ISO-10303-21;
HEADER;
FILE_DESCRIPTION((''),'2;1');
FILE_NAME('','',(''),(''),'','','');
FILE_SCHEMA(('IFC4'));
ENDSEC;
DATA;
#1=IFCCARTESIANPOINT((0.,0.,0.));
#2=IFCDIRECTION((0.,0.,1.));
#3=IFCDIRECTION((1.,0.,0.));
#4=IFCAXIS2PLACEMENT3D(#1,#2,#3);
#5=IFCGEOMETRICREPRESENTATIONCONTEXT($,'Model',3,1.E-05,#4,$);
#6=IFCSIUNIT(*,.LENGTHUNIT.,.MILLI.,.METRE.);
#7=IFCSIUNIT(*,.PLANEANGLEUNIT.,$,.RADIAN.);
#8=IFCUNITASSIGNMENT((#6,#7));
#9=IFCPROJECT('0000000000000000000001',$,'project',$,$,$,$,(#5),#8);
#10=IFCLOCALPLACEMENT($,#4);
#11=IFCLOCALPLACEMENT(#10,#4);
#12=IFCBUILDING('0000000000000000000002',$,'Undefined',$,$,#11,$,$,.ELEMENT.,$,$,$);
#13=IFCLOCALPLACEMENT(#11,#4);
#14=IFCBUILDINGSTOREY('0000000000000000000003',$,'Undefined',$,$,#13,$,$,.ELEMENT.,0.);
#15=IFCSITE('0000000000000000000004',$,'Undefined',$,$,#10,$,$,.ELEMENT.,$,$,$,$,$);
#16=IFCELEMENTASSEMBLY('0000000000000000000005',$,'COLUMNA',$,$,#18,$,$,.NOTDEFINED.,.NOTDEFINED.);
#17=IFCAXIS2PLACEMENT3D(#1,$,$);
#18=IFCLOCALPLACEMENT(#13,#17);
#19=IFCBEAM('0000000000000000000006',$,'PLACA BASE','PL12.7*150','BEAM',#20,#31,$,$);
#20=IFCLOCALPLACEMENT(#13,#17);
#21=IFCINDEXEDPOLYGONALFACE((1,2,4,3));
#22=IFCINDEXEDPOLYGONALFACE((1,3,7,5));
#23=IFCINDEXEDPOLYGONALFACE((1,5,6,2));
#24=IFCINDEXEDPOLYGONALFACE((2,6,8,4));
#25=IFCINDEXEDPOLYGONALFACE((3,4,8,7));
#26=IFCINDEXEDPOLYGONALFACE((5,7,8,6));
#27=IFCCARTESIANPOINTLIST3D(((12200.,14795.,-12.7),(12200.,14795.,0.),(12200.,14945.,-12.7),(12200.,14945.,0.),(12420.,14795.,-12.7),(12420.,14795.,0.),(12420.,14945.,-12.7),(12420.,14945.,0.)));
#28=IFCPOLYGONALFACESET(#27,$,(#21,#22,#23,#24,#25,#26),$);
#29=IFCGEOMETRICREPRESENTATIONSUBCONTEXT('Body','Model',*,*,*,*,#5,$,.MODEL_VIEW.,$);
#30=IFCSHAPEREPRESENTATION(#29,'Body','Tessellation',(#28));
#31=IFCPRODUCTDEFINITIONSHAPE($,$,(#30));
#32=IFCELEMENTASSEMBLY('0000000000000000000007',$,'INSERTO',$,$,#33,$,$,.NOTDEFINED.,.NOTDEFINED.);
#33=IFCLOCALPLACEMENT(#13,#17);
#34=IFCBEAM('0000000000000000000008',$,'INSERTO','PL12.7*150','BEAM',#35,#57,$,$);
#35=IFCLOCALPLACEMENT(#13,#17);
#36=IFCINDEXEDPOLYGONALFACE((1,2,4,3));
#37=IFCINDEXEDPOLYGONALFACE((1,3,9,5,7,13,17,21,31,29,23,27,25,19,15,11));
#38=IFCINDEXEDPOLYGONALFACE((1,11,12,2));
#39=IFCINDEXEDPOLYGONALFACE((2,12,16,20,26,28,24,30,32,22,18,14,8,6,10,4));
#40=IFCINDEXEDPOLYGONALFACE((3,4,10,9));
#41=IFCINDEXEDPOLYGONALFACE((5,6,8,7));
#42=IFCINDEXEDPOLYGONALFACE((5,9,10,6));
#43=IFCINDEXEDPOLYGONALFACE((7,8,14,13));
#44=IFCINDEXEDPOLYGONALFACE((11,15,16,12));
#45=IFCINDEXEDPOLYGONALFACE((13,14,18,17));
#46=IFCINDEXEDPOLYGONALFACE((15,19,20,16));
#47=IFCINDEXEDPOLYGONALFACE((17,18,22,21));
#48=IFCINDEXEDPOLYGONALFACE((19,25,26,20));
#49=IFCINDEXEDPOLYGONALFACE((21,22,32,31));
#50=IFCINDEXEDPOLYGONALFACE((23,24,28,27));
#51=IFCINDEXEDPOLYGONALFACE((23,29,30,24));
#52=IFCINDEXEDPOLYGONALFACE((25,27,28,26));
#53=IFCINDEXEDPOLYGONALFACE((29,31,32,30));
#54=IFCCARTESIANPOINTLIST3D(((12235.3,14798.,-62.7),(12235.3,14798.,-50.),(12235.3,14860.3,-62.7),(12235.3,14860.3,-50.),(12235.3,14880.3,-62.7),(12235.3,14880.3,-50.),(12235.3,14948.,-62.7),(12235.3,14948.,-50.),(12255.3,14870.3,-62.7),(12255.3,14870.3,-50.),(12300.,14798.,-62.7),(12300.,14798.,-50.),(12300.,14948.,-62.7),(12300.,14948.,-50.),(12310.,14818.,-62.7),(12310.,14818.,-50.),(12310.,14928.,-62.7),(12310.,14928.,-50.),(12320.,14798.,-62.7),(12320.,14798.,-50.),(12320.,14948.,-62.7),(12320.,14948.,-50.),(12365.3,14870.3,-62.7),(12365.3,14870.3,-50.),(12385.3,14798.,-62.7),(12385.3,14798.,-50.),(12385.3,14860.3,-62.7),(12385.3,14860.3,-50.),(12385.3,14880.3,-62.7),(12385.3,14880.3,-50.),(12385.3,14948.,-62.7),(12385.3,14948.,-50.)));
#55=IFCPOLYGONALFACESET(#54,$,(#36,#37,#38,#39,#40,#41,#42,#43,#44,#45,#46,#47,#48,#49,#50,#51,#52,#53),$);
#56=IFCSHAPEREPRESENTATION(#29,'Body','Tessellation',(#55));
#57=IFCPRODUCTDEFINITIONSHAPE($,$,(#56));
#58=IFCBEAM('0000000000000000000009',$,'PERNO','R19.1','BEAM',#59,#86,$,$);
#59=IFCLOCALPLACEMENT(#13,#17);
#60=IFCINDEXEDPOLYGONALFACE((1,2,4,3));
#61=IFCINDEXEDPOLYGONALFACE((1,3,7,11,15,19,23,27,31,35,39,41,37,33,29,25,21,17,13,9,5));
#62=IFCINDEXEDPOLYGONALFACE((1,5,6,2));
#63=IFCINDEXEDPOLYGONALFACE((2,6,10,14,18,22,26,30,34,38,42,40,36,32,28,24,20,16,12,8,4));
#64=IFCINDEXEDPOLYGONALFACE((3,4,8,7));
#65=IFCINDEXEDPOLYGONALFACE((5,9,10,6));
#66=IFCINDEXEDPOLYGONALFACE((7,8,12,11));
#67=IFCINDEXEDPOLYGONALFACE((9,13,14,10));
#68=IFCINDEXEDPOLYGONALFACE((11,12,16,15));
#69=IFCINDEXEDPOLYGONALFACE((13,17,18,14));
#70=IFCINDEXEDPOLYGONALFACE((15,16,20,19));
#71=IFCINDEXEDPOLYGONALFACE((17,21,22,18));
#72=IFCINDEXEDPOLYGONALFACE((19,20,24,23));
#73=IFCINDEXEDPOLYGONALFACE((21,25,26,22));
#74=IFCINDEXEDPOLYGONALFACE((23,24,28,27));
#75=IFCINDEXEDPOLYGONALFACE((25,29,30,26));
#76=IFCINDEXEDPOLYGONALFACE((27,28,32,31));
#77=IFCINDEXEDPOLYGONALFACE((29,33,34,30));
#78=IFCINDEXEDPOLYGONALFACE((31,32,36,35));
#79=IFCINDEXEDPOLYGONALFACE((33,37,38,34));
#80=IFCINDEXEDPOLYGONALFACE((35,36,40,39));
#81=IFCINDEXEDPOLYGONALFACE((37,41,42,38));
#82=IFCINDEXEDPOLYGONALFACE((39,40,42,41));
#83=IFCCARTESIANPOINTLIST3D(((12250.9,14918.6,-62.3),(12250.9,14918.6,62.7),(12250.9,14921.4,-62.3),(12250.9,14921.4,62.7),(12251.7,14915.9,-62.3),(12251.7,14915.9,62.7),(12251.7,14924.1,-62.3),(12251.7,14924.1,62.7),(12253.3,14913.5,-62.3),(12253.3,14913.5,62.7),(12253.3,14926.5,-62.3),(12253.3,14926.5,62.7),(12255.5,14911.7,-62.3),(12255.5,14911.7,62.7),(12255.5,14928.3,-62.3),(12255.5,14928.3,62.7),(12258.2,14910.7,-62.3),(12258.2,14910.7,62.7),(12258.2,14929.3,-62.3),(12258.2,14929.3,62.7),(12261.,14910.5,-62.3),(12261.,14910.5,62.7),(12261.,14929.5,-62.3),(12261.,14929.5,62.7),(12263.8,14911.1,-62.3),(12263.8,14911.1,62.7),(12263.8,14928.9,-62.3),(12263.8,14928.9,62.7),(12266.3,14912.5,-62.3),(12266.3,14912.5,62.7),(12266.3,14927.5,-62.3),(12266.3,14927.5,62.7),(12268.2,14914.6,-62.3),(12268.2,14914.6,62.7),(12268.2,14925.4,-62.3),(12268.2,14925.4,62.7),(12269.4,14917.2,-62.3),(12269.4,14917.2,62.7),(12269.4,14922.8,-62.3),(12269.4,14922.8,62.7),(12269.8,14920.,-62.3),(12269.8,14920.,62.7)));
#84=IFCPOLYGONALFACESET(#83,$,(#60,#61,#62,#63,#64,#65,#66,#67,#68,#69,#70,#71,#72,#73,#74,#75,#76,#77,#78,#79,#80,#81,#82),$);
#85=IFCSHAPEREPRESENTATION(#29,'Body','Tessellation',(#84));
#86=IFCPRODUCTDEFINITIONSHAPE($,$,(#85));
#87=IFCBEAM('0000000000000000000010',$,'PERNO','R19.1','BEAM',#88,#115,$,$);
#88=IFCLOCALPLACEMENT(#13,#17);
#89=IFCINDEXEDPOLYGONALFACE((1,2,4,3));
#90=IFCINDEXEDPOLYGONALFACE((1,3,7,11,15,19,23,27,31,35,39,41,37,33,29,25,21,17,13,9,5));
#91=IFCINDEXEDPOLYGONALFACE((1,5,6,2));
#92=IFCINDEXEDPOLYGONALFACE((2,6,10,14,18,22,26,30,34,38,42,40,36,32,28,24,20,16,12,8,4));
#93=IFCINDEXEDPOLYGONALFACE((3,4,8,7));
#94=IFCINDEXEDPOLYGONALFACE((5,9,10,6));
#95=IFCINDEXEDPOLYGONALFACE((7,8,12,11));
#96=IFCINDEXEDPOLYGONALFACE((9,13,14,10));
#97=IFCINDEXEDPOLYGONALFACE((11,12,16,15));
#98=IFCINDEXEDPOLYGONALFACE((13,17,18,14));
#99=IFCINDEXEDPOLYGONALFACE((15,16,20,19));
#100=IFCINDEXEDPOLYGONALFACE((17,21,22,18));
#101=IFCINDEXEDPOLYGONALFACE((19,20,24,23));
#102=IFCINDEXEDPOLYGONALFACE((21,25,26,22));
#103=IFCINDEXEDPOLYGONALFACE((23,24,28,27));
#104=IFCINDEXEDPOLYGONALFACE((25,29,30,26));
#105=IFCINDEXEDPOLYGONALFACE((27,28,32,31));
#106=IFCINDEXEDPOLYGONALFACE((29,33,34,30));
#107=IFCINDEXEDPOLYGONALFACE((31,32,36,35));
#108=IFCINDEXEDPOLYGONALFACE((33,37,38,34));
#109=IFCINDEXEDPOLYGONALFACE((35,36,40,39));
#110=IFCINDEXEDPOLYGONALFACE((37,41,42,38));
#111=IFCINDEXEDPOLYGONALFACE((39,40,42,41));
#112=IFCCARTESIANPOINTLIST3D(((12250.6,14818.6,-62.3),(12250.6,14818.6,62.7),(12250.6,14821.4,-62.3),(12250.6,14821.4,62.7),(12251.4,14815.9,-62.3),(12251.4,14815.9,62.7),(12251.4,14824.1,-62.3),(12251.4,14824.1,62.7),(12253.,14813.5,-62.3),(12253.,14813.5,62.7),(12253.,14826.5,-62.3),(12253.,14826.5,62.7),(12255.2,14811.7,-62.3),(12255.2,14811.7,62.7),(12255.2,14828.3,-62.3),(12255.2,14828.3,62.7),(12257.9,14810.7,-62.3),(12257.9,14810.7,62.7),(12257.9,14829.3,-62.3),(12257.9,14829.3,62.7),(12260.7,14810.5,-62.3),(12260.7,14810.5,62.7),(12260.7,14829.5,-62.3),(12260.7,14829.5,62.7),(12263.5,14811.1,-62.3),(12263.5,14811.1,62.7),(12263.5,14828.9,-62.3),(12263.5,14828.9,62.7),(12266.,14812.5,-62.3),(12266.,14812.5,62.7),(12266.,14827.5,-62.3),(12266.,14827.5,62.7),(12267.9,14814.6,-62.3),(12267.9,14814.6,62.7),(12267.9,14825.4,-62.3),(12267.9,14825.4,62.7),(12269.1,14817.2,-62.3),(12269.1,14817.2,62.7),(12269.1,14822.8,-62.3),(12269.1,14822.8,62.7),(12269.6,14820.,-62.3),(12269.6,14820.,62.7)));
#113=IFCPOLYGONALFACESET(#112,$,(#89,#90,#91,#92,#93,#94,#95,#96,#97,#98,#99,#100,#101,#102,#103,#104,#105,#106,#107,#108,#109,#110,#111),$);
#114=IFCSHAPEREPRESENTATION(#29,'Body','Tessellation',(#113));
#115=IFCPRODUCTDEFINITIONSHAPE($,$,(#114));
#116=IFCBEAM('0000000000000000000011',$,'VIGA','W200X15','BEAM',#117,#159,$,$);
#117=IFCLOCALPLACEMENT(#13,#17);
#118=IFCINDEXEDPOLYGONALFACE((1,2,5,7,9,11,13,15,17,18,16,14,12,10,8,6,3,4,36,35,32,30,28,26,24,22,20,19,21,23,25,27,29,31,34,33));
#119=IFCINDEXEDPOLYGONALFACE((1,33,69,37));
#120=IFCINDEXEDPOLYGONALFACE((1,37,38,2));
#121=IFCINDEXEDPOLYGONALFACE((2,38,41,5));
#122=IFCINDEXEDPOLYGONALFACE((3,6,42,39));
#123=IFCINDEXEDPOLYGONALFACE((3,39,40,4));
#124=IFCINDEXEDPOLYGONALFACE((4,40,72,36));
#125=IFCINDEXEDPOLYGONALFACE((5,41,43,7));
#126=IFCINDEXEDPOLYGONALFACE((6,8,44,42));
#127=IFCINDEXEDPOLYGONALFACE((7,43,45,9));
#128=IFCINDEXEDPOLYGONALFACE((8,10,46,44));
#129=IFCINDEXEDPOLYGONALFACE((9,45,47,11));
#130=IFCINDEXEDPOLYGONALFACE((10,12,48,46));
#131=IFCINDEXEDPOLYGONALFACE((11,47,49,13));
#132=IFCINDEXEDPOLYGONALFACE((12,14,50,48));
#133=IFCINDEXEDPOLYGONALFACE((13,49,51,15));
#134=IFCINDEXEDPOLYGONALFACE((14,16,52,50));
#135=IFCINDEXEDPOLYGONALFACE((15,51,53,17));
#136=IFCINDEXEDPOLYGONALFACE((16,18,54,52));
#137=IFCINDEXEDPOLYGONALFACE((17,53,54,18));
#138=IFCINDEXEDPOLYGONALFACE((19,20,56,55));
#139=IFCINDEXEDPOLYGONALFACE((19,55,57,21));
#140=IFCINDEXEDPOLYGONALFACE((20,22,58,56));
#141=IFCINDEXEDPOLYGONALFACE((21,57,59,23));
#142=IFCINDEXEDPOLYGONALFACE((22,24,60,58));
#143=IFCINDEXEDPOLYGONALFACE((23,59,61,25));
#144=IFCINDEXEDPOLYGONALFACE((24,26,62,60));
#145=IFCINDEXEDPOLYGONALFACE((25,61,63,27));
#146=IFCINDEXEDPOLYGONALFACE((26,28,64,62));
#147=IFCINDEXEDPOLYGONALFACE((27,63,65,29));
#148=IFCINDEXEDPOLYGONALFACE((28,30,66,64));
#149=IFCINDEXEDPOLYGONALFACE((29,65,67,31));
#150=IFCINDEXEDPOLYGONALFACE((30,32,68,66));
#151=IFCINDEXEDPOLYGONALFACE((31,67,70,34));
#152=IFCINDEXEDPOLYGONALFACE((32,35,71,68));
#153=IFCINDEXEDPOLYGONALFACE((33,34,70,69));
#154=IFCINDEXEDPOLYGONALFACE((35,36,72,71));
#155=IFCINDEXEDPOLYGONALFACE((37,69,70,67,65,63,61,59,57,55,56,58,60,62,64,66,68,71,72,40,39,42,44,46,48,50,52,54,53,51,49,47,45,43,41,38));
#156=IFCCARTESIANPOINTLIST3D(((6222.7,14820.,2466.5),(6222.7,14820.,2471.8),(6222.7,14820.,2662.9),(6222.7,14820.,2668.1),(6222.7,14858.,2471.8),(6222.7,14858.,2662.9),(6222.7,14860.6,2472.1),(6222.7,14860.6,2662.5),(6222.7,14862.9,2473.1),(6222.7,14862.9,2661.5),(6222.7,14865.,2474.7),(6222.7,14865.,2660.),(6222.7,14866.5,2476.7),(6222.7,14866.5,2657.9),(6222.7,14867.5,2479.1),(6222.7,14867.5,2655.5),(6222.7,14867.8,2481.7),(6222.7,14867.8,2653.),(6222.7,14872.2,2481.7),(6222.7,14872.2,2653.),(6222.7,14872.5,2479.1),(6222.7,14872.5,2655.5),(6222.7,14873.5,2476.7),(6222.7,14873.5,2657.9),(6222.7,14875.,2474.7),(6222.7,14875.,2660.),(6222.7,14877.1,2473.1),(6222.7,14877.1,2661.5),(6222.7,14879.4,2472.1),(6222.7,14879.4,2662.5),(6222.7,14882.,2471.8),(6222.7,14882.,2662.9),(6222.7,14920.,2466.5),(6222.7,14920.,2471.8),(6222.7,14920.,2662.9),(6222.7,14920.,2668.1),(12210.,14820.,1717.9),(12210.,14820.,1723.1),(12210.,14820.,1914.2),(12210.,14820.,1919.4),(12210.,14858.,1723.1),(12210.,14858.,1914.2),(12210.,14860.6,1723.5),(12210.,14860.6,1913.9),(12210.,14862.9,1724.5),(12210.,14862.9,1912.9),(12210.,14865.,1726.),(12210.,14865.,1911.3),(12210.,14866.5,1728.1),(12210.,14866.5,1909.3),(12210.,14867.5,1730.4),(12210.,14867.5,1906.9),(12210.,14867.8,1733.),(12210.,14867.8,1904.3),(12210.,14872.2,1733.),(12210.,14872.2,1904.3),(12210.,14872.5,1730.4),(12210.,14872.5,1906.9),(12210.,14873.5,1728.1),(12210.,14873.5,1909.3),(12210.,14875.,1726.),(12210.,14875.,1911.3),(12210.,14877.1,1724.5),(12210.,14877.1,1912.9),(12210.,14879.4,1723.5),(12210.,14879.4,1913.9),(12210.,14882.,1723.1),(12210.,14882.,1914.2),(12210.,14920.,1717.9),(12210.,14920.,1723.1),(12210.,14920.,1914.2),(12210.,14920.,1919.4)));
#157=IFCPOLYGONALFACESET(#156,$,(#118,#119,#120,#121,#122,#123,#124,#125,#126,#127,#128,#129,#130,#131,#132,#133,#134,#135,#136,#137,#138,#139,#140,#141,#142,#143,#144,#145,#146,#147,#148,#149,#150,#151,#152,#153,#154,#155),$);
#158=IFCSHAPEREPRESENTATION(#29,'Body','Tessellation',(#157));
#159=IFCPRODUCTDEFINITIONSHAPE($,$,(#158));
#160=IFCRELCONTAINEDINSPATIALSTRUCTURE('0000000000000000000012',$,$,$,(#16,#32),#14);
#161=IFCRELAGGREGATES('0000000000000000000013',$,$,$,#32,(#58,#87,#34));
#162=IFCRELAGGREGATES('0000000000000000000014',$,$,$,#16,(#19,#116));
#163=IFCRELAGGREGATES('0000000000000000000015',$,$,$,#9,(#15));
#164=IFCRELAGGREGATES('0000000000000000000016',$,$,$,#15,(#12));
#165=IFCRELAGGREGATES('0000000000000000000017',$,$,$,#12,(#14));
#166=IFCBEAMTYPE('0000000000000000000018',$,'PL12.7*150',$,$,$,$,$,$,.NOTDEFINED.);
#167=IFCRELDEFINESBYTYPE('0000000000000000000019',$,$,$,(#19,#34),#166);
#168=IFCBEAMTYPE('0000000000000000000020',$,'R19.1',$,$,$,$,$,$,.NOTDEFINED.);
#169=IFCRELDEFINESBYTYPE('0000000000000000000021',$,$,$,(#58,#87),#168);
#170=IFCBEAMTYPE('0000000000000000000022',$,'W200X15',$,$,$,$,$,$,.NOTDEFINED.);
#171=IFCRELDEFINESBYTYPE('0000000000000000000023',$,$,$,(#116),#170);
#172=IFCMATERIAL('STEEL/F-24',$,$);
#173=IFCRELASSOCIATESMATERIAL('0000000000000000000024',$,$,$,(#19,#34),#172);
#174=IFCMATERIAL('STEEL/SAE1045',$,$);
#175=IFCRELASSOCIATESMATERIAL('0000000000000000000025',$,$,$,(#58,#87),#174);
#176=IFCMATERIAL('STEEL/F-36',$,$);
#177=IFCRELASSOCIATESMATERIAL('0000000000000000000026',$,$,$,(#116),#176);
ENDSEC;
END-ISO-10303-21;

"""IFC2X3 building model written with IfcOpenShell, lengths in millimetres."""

from ifc_helpers import new_model, si_unit, frame, origin_with_axes, origin_2d_with_axis, place, context, subcontext, project, spatial, polyline, rectangle, circle, i_section, outline, extrude, boolean, clip, halfspace, material, type_object, element, aggregate, save


model = new_model("IFC2X3")

# Units and contexts
model_context = context("Model", 3, precision=1e-05, world=origin_with_axes())
body_context = subcontext(model_context, "Body", "Model", "MODEL_VIEW")
ifc_project = project(units=[si_unit("LENGTHUNIT", "METRE", prefix="MILLI"), si_unit("PLANEANGLEUNIT", "RADIAN")], contexts=[model_context])

# Site, building, storey
site_placement = place(None, origin_with_axes())
site = spatial("IfcSite", under=ifc_project, at=site_placement, Name="Undefined", CompositionType="ELEMENT")
building_placement = place(site_placement, origin_with_axes())
building = spatial("IfcBuilding", under=site, at=building_placement, Name="Undefined", CompositionType="ELEMENT")
storey_placement = place(building_placement, origin_with_axes())
storey = spatial("IfcBuildingStorey", under=building, at=storey_placement, Name="Undefined", CompositionType="ELEMENT", Elevation=0.0)

# Element assembly, beam
assembly_1_placement = place(storey_placement, origin_with_axes())
assembly_1 = element("IfcElementAssembly", 1, at=assembly_1_placement, inside=storey, Name="COLUMNA", AssemblyPlace="NOTDEFINED", PredefinedType="NOTDEFINED")
ifc_material_1 = material(Name="STEEL/F-24")
beam_type_1 = type_object("IfcBeamType", Name="PL12.7*150", PredefinedType="NOTDEFINED")
beam_1_placement = place(assembly_1_placement, frame((12200.0, 14870.0, -6.4), z_axis=(0.0, -1.0, 0.0), x_axis=(1.0, 0.0, 0.0)))
beam_1 = element("IfcBeam", 2, at=beam_1_placement, type_object=beam_type_1, material=ifc_material_1, Name="PLACA BASE", Description="PL12.7*150", ObjectType="BEAM", context=body_context, shape_type="SweptSolid", body=[
    extrude(rectangle(XDim=12.7, YDim=150.0, at=origin_2d_with_axis()), frame((220.0, 0.0, 0.0), z_axis=(-1.0, 0.0, 0.0), x_axis=(0.0, -1.0, 0.0)), (0.0, 0.0, 1.0), 220.0),
])

# Element assembly, beams
assembly_2_placement = place(storey_placement, origin_with_axes())
assembly_2 = element("IfcElementAssembly", 3, at=assembly_2_placement, inside=storey, Name="INSERTO", AssemblyPlace="NOTDEFINED", PredefinedType="NOTDEFINED")
beam_2_placement = place(assembly_2_placement, frame((12235.3, 14873.0, -56.3), z_axis=(0.0, 1.0, 0.0), x_axis=(1.0, 0.0, 0.0)))
beam_2 = element("IfcBeam", 4, at=beam_2_placement, type_object=beam_type_1, material=ifc_material_1, Name="INSERTO", Description="PL12.7*150", ObjectType="BEAM", context=body_context, shape_type="CSG", body=[
    boolean("DIFFERENCE", boolean("DIFFERENCE", boolean("DIFFERENCE", boolean("DIFFERENCE", extrude(rectangle(XDim=12.7, YDim=150.0, at=origin_2d_with_axis()), frame((150.0, 0.0, 0.0), z_axis=(-1.0, 0.0, 0.0), x_axis=(0.0, -1.0, 0.0)), (0.0, 0.0, 1.0), 150.0), extrude(outline(polyline([(0.0, 0.0), (20.0, 0.0), (10.0, 20.0), (0.0, 0.0)])), frame((0.0, -9.0, -12.7), z_axis=(0.0, 1.0, 0.0), x_axis=(0.0, 0.0, 1.0)), (0.0, 0.0, 1.0), 18.0)), extrude(outline(polyline([(0.0, 0.0), (20.0, 0.0), (10.0, 20.0), (0.0, 0.0)])), frame((150.0, 9.0, -12.7), z_axis=(0.0, -1.0, 0.0), x_axis=(0.0, 0.0, 1.0)), (0.0, 0.0, 1.0), 18.0)), extrude(outline(polyline([(0.0, 0.0), (20.0, 0.0), (10.0, 20.0), (0.0, 0.0)])), frame((64.7, -9.0, 75.0), z_axis=(0.0, 1.0, 0.0), x_axis=(1.0, 0.0, 0.0)), (0.0, 0.0, 1.0), 18.0)), extrude(outline(polyline([(0.0, 0.0), (20.0, 0.0), (10.0, 20.0), (0.0, 0.0)])), frame((64.7, 9.0, -75.0), z_axis=(0.0, -1.0, 0.0), x_axis=(1.0, 0.0, 0.0)), (0.0, 0.0, 1.0), 18.0)),
])
ifc_material_2 = material(Name="STEEL/SAE1045")
beam_type_2 = type_object("IfcBeamType", Name="R19.1", PredefinedType="NOTDEFINED")
beam_3_placement = place(assembly_2_placement, frame((12260.3, 14920.0, -62.3), z_axis=(0.0, -1.0, 0.0), x_axis=(0.0, 0.0, 1.0)))
beam_3 = element("IfcBeam", 5, at=beam_3_placement, type_object=beam_type_2, material=ifc_material_2, Name="PERNO", Description="R19.1", ObjectType="BEAM", context=body_context, shape_type="SweptSolid", body=[
    extrude(circle(Radius=9.6, at=origin_2d_with_axis()), frame((125.0, 0.0, 0.0), z_axis=(-1.0, 0.0, 0.0), x_axis=(0.0, -1.0, 0.0)), (0.0, 0.0, 1.0), 125.0),
])
beam_4_placement = place(assembly_2_placement, frame((12260.0, 14820.0, -62.3), z_axis=(0.0, -1.0, 0.0), x_axis=(0.0, 0.0, 1.0)))
beam_4 = element("IfcBeam", 6, at=beam_4_placement, type_object=beam_type_2, material=ifc_material_2, Name="PERNO", Description="R19.1", ObjectType="BEAM", context=body_context, shape_type="SweptSolid", body=[
    extrude(circle(Radius=9.6, at=origin_2d_with_axis()), frame((125.0, 0.0, 0.0), z_axis=(-1.0, 0.0, 0.0), x_axis=(0.0, -1.0, 0.0)), (0.0, 0.0, 1.0), 125.0),
])

# Beam
ifc_material_3 = material(Name="STEEL/F-36")
beam_type_3 = type_object("IfcBeamType", Name="W200X15", PredefinedType="NOTDEFINED")
beam_5_placement = place(assembly_1_placement, frame((12210.0, 14870.0, 1818.7), z_axis=(0.124075, 0.0, 0.992273), x_axis=(-0.992273, 0.0, 0.124075)))
beam_5 = element("IfcBeam", 7, at=beam_5_placement, type_object=beam_type_3, material=ifc_material_3, Name="VIGA", Description="W200X15", ObjectType="BEAM", context=body_context, shape_type="Clipping", body=[
    clip(clip(extrude(i_section(OverallWidth=100.0, OverallDepth=200.0, WebThickness=4.3, FlangeThickness=5.2, FilletRadius=9.8, at=origin_2d_with_axis()), frame((6059.2, 0.0, 0.0), z_axis=(-1.0, 0.0, 0.0), x_axis=(0.0, -1.0, 0.0)), (0.0, 0.0, 1.0), 6084.4), halfspace(frame((6033.9, 0.0, 0.0), z_axis=(0.992273, 0.0, -0.124075), x_axis=(0.0, 1.0, 0.0)), False)), halfspace(frame((0.0, 0.0, 0.0), z_axis=(0.992273, 0.0, -0.124075), x_axis=(0.0, -1.0, 0.0)), True)),
])

aggregate(assembly_2, [beam_3, beam_4, beam_2])

aggregate(assembly_1, [beam_1, beam_5])

save(model, "model.ifc")
